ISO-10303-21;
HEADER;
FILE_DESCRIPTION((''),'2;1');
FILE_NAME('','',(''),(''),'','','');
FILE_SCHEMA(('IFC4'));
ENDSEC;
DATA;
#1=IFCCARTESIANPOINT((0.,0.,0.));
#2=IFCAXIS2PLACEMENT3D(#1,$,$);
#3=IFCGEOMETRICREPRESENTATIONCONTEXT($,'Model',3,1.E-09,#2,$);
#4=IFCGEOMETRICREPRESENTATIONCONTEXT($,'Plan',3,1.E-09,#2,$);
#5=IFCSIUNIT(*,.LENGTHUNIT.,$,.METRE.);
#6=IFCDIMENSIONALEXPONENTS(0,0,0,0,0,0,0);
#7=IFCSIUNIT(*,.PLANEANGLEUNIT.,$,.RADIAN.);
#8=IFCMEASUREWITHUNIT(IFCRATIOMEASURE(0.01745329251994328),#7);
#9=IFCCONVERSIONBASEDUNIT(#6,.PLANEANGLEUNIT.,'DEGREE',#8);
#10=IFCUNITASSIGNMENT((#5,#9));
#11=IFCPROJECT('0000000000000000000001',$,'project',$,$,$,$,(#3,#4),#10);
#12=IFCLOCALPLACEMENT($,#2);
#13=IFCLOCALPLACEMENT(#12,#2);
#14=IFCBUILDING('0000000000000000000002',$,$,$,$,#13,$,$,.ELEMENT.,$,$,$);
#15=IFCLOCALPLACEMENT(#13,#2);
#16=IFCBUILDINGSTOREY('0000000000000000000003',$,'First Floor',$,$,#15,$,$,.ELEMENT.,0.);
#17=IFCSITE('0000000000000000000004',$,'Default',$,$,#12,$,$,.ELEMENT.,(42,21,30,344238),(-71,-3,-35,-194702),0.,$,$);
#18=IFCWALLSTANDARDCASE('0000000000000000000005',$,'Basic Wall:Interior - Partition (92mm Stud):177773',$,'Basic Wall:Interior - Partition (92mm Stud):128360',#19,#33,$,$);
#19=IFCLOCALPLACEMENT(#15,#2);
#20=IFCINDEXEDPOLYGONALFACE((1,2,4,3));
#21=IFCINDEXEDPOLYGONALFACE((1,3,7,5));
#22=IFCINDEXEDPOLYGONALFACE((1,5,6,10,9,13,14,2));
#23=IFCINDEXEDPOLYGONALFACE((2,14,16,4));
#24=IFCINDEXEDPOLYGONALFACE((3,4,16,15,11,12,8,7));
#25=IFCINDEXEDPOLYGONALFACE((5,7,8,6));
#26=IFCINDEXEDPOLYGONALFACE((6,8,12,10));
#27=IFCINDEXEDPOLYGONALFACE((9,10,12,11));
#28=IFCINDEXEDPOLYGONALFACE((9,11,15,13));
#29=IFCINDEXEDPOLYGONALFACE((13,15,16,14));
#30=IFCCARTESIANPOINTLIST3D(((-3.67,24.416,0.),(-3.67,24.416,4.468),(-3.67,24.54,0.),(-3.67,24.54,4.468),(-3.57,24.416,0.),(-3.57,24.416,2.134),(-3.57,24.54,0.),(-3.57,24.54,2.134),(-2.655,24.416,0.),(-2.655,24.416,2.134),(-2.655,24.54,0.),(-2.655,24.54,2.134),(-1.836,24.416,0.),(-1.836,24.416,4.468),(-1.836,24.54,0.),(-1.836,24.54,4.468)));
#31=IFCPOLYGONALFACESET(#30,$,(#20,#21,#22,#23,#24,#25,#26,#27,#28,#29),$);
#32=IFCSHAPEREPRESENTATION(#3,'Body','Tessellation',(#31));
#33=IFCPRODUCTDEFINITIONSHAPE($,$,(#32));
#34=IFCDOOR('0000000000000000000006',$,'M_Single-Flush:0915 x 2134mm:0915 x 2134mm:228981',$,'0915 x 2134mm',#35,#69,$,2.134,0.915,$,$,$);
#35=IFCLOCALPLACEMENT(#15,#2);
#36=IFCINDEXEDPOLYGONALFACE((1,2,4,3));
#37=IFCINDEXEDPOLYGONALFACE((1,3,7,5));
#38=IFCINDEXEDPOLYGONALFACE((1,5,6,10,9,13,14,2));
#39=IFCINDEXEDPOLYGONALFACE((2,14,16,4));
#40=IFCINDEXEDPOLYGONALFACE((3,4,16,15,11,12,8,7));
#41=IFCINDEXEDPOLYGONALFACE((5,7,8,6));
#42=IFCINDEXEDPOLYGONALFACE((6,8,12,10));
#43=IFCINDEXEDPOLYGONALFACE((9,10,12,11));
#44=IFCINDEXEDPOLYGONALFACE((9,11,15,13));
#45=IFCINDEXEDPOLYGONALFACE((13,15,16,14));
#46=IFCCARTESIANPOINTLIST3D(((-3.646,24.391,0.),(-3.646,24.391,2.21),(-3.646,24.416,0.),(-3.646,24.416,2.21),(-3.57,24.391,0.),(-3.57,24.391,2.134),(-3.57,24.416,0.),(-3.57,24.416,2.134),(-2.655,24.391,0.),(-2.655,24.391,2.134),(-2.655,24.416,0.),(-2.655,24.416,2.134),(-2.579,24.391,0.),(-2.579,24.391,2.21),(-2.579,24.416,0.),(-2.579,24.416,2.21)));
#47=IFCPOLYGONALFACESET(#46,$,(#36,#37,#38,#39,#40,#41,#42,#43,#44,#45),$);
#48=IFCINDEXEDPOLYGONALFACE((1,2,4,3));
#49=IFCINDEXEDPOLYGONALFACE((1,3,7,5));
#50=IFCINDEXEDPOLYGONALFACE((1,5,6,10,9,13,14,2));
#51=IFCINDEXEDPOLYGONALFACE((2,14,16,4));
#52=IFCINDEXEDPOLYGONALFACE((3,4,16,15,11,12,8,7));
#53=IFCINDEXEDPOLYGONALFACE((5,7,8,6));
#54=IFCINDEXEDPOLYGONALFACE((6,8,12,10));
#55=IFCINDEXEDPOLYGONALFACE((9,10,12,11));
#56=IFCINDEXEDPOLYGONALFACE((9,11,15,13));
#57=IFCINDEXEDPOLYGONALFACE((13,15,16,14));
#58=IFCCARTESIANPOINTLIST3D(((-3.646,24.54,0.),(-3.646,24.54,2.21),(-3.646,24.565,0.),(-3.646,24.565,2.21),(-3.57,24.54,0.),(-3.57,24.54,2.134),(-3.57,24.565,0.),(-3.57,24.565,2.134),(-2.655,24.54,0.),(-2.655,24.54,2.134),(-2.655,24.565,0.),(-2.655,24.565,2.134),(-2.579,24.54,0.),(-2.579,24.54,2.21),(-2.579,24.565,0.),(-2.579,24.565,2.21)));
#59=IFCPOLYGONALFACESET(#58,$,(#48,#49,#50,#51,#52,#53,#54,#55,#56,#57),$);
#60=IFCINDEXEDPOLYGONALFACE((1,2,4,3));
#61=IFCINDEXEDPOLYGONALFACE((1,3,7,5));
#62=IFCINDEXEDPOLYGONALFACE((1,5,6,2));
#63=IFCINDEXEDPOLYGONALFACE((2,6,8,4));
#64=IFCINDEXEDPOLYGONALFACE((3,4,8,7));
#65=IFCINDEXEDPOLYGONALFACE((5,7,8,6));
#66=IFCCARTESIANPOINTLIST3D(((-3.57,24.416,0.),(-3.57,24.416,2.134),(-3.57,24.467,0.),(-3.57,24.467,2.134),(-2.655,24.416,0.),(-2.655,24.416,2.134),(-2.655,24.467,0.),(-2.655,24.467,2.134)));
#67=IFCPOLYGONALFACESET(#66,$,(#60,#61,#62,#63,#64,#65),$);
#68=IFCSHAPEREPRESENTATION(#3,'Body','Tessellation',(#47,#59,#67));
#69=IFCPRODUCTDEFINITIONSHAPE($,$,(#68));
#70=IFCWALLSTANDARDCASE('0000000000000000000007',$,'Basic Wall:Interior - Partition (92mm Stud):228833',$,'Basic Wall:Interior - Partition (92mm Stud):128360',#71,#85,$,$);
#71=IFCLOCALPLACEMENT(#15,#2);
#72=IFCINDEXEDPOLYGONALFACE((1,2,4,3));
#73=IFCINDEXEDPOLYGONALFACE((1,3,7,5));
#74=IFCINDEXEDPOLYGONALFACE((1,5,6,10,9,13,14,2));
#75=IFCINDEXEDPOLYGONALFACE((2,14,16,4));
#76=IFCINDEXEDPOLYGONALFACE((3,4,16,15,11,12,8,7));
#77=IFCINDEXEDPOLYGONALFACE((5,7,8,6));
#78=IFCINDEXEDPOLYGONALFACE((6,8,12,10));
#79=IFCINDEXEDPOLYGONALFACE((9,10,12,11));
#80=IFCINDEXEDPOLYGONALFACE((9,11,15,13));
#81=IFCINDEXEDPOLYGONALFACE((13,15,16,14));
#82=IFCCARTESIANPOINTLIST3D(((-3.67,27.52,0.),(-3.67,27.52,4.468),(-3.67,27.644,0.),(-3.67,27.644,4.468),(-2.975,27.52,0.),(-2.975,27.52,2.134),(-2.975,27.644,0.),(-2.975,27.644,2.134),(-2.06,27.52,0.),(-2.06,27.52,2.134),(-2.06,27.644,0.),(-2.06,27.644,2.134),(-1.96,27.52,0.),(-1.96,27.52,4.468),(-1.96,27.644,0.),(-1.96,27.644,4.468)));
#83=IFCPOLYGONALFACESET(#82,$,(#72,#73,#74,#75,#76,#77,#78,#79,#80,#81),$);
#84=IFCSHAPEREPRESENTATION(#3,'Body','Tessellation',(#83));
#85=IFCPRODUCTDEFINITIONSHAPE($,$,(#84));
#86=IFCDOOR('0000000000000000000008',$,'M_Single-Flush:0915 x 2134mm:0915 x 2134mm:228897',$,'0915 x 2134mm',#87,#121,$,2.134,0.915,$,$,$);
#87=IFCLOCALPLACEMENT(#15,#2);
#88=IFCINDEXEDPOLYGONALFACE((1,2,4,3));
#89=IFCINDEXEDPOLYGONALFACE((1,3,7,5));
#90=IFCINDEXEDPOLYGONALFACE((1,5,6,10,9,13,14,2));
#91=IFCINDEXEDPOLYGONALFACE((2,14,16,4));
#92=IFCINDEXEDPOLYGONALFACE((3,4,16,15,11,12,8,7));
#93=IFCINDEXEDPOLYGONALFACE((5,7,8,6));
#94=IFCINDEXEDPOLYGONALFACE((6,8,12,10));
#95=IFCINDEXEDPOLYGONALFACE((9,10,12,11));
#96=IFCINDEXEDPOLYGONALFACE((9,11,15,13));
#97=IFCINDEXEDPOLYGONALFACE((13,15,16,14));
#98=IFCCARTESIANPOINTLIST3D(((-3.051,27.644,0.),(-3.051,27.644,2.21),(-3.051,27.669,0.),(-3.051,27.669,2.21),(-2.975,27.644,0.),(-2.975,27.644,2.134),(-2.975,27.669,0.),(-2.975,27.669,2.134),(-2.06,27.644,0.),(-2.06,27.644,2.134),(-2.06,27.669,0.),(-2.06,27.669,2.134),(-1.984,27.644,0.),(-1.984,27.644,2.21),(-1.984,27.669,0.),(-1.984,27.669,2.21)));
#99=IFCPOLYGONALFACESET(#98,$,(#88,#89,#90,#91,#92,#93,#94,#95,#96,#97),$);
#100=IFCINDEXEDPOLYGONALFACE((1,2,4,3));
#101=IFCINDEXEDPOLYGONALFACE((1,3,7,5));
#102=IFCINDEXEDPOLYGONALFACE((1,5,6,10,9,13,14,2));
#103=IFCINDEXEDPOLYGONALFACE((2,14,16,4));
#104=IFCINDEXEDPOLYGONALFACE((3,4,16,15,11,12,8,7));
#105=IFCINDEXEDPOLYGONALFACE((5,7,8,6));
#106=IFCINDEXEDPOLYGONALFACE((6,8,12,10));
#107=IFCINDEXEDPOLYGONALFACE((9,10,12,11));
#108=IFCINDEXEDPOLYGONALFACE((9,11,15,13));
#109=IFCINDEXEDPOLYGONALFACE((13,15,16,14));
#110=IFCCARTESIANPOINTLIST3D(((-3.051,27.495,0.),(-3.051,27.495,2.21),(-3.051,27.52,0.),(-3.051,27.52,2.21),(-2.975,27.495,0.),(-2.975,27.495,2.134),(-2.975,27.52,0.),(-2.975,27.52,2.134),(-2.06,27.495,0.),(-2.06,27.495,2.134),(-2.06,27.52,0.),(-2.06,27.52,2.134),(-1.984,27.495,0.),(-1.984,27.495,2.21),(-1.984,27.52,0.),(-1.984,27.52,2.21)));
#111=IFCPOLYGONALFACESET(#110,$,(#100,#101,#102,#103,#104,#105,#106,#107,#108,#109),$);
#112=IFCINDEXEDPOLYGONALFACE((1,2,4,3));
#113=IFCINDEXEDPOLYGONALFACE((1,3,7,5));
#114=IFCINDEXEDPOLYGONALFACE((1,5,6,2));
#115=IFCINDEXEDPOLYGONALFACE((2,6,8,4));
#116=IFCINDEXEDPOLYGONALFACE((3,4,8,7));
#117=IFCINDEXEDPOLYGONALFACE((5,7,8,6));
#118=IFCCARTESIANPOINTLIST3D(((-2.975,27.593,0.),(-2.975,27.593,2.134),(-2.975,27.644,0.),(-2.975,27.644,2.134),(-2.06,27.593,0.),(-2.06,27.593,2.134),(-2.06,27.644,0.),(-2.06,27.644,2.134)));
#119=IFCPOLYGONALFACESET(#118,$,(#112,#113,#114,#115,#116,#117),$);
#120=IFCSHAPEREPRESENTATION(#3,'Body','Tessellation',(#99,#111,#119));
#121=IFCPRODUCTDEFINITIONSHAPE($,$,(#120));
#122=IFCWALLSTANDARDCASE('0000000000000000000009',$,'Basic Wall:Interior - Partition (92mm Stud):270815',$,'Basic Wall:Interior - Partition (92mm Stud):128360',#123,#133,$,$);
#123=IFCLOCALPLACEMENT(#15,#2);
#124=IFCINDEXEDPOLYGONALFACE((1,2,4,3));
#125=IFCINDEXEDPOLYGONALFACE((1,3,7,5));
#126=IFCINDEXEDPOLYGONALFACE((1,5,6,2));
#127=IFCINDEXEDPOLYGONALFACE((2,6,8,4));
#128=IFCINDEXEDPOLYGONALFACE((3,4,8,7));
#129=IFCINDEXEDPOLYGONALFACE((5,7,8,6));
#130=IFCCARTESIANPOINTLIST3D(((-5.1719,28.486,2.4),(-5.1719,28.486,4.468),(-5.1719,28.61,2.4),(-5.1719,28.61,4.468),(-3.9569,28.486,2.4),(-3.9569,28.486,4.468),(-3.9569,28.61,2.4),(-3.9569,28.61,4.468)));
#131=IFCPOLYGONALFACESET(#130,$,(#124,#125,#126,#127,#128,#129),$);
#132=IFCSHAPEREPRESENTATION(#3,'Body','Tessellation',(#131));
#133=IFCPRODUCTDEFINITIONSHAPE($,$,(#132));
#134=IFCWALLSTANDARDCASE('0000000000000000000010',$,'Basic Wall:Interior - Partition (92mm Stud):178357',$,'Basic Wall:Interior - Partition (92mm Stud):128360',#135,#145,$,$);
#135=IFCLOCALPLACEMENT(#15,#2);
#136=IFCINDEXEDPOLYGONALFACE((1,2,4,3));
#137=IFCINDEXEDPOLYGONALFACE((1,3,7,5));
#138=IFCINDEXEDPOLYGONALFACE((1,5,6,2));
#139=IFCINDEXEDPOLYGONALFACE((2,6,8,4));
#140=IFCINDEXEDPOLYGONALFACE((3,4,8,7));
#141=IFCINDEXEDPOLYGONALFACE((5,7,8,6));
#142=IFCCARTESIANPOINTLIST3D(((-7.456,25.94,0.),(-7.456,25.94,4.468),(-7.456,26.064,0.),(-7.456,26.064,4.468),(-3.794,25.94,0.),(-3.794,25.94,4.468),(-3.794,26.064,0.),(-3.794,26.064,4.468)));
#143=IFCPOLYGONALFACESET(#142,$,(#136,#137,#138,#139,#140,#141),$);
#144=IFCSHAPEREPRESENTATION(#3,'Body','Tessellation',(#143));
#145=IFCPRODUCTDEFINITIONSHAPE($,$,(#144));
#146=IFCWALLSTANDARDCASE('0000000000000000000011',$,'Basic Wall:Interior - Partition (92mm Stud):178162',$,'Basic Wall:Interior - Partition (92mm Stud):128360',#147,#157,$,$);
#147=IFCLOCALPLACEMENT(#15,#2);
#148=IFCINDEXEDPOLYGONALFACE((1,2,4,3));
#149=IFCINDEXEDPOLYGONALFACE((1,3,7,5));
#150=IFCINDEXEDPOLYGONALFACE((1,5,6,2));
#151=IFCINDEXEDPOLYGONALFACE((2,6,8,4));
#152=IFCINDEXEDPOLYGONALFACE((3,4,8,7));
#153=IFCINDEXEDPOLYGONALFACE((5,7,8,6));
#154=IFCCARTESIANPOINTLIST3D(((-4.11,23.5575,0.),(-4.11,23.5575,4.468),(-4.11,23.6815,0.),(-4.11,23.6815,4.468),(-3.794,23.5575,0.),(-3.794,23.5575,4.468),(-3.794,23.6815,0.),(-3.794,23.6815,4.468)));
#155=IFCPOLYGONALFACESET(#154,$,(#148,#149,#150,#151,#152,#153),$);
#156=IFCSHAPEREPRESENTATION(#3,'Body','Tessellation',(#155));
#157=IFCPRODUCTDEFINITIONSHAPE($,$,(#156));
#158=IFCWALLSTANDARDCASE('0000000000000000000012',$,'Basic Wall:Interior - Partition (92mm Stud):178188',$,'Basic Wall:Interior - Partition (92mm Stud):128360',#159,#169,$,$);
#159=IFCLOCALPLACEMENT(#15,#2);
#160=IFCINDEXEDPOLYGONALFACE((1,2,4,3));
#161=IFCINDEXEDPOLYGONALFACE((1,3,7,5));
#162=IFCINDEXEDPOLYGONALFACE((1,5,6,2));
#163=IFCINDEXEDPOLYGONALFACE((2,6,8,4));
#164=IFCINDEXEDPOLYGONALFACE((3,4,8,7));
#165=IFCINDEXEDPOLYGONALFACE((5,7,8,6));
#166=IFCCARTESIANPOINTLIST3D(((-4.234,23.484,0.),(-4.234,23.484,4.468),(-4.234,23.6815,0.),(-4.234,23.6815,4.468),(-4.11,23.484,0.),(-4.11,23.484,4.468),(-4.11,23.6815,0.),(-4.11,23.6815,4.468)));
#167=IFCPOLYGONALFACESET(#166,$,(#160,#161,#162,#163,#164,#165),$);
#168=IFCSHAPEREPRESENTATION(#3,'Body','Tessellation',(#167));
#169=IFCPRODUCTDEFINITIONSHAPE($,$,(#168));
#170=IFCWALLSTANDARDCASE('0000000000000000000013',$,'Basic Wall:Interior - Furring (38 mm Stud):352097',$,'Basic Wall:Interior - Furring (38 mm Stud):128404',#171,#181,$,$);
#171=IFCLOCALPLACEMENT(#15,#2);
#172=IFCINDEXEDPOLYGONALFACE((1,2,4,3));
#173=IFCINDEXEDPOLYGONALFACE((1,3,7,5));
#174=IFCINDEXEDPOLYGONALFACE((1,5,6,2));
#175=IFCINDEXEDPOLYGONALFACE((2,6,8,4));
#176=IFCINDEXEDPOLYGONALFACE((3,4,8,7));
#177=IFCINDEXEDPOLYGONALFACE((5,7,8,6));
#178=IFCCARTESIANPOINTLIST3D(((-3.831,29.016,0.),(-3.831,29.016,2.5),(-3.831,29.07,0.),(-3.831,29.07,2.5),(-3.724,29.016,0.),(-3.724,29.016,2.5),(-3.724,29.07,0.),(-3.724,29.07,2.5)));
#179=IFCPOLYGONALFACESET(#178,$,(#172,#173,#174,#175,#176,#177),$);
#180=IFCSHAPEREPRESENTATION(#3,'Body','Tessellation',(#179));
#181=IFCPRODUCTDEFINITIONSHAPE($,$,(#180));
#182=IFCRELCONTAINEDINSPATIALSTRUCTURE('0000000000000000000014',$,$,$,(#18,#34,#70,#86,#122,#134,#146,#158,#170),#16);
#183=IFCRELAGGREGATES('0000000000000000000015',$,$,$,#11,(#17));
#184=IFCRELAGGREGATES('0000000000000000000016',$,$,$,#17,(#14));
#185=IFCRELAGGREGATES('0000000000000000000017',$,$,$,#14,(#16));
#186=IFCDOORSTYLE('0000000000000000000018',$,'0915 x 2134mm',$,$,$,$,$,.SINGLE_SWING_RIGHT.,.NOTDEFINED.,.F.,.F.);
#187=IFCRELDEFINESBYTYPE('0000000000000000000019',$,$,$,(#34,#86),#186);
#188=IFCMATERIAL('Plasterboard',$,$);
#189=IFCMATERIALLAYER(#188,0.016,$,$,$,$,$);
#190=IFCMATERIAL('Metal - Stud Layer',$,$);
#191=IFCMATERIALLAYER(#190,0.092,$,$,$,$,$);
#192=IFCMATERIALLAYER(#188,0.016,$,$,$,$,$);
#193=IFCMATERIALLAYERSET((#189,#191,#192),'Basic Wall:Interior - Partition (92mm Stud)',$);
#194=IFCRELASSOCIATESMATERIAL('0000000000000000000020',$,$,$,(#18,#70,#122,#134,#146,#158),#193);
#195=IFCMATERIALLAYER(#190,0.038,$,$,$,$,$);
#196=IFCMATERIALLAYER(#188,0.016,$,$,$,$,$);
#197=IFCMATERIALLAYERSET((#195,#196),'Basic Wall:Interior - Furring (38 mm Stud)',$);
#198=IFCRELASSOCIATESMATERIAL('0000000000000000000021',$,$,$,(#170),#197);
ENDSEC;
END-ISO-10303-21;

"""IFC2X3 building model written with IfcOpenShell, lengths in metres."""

from ifc_helpers import new_model, entity, si_unit, converted_unit, frame, frame_2d, origin, origin_2d_with_axis, place, context, project, spatial, polyline, rectangle, outline, extrude, source, transform, mapped, material, layer, layer_set, layer_usage, type_object, type_shapes, element, fill, save


model = new_model("IFC2X3")

# Units and contexts
model_context = context("Model", 3, precision=1e-09, world=origin())
plan_context = context("Plan", 3, precision=1e-09, world=origin())
ifc_project = project(units=[si_unit("LENGTHUNIT", "METRE"), converted_unit("PLANEANGLEUNIT", "DEGREE", entity("IfcRatioMeasure", 0.01745329251994328), si_unit("PLANEANGLEUNIT", "RADIAN"), dimensions=[0, 0, 0, 0, 0, 0, 0])], contexts=[model_context, plan_context])

# Site, building, storey
site_placement = place(None, origin())
site = spatial("IfcSite", under=ifc_project, at=site_placement, Name="Default", CompositionType="ELEMENT", RefLatitude=(42, 21, 30, 344238), RefLongitude=(-71, -3, -35, -194702), RefElevation=0.0)
building_placement = place(site_placement, origin())
building = spatial("IfcBuilding", under=site, at=building_placement, CompositionType="ELEMENT")
storey_placement = place(building_placement, origin())
storey = spatial("IfcBuildingStorey", under=building, at=storey_placement, Name="First Floor", CompositionType="ELEMENT", Elevation=0.0)

# Shared definitions
ifc_material_1 = material(Name="Plasterboard")
ifc_layer_1 = layer(ifc_material_1, 0.016)
ifc_material_2 = material(Name="Metal - Stud Layer")
ifc_layer_2 = layer(ifc_material_2, 0.092)
ifc_layer_3 = layer(ifc_material_1, 0.016)
ifc_layer_set_1 = layer_set([ifc_layer_1, ifc_layer_2, ifc_layer_3], Name="Basic Wall:Interior - Partition (92mm Stud)")
ifc_layer_usage_1 = layer_usage(ifc_layer_set_1, "AXIS2", "NEGATIVE", 0.062)
door_style_1 = type_object("IfcDoorStyle", Name="0915 x 2134mm", ConstructionType="NOTDEFINED", OperationType="SINGLE_SWING_RIGHT", ParameterTakesPrecedence=False, Sizeable=False)
shared_shape_1 = source(origin(), model_context, "Body", "SweptSolid", [
    extrude(outline(polyline([(-0.5335, -1.124), (0.5335, -1.124), (0.5335, 1.086), (0.4575, 1.086), (0.4575, -1.048), (-0.4575, -1.048), (-0.4575, 1.086), (-0.5335, 1.086), (-0.5335, -1.124)])), frame((0.4575, 0.124, 1.086), z_axis=(0.0, 1.0, 0.0), x_axis=(1.0, 0.0, 0.0)), (0.0, 0.0, 1.0), 0.025),
    extrude(outline(polyline([(-1.124, -0.5335), (1.086, -0.5335), (1.086, -0.4575), (-1.048, -0.4575), (-1.048, 0.4575), (1.086, 0.4575), (1.086, 0.5335), (-1.124, 0.5335), (-1.124, -0.5335)])), frame((0.4575, -0.025, 1.086), z_axis=(0.0, 1.0, 0.0), x_axis=(0.0, 0.0, -1.0)), (0.0, 0.0, 1.0), 0.025),
    extrude(rectangle(XDim=0.051, YDim=0.915, at=origin_2d_with_axis()), frame((0.4575, 0.0985, 0.0), z_axis=(0.0, 0.0, 1.0), x_axis=(0.0, 1.0, 0.0)), (0.0, 0.0, 1.0), 2.134),
])
type_shapes(door_style_1, [shared_shape_1])

# Shared definitions
ifc_layer_4 = layer(ifc_material_2, 0.038)
ifc_layer_5 = layer(ifc_material_1, 0.016)
ifc_layer_set_2 = layer_set([ifc_layer_4, ifc_layer_5], Name="Basic Wall:Interior - Furring (38 mm Stud)")
ifc_layer_usage_2 = layer_usage(ifc_layer_set_2, "AXIS2", "POSITIVE", -0.027)

# Walls, openings, doors
wall_1_placement = place(storey_placement, frame((-3.67, 24.478, 0.0)))
wall_1 = element("IfcWallStandardCase", 1, at=wall_1_placement, inside=storey, material=ifc_layer_usage_1, Name="Basic Wall:Interior - Partition (92mm Stud):177773", ObjectType="Basic Wall:Interior - Partition (92mm Stud):128360", context=model_context, shape_type="SweptSolid", body=[
    extrude(rectangle(XDim=1.834, YDim=0.124, at=frame_2d((0.917, 0.0), x_axis=(-1.0, 0.0))), origin(), (0.0, 0.0, 1.0), 4.468),
])
opening_1_placement = place(wall_1_placement, frame((1.015, 0.062, 0.0)))
opening_1 = element("IfcOpeningElement", 2, at=opening_1_placement, cuts=wall_1, ObjectType="Opening", context=model_context, shape_type="SweptSolid", body=[
    extrude(rectangle(XDim=0.915, YDim=2.134, at=frame_2d((1.067, 0.4575), x_axis=(0.0, 1.0))), frame((0.0, 0.0, 0.0), z_axis=(0.0, -1.0, 0.0), x_axis=(0.0, 0.0, 1.0)), (0.0, 0.0, 1.0), 0.124),
])
door_1_placement = place(opening_1_placement, frame((0.0, 0.0, 0.0), z_axis=(0.0, 0.0, 1.0), x_axis=(-1.0, 0.0, 0.0)))
door_1 = element("IfcDoor", 3, at=door_1_placement, inside=storey, type_object=door_style_1, Name="M_Single-Flush:0915 x 2134mm:0915 x 2134mm:228981", ObjectType="0915 x 2134mm", OverallHeight=2.134, OverallWidth=0.915, context=model_context, shape_type="MappedRepresentation", body=[
    mapped(shared_shape_1, transform((0.0, 0.0, 0.0), scale=1.0)),
])
fill(opening_1, door_1)
wall_2_placement = place(storey_placement, frame((-1.96, 27.582, 0.0), z_axis=(0.0, 0.0, 1.0), x_axis=(-1.0, 0.0, 0.0)))
wall_2 = element("IfcWallStandardCase", 4, at=wall_2_placement, inside=storey, material=ifc_layer_usage_1, Name="Basic Wall:Interior - Partition (92mm Stud):228833", ObjectType="Basic Wall:Interior - Partition (92mm Stud):128360", context=model_context, shape_type="SweptSolid", body=[
    extrude(rectangle(XDim=1.71, YDim=0.124, at=frame_2d((0.855, 0.0), x_axis=(-1.0, 0.0))), origin(), (0.0, 0.0, 1.0), 4.468),
])
opening_2_placement = place(wall_2_placement, frame((1.015, 0.062, 0.0)))
opening_2 = element("IfcOpeningElement", 5, at=opening_2_placement, cuts=wall_2, ObjectType="Opening", context=model_context, shape_type="SweptSolid", body=[
    extrude(rectangle(XDim=0.915, YDim=2.134, at=frame_2d((1.067, 0.4575), x_axis=(0.0, 1.0))), frame((0.0, 0.0, 0.0), z_axis=(0.0, -1.0, 0.0), x_axis=(0.0, 0.0, 1.0)), (0.0, 0.0, 1.0), 0.124),
])
door_2_placement = place(opening_2_placement, frame((0.0, 0.0, 0.0), z_axis=(0.0, 0.0, 1.0), x_axis=(-1.0, 0.0, 0.0)))
door_2 = element("IfcDoor", 6, at=door_2_placement, inside=storey, type_object=door_style_1, Name="M_Single-Flush:0915 x 2134mm:0915 x 2134mm:228897", ObjectType="0915 x 2134mm", OverallHeight=2.134, OverallWidth=0.915, context=model_context, shape_type="MappedRepresentation", body=[
    mapped(shared_shape_1, transform((0.0, 0.0, 0.0), scale=1.0)),
])
fill(opening_2, door_2)

# Walls
wall_3_placement = place(storey_placement, frame((-3.9569, 28.548, 2.4), z_axis=(0.0, 0.0, 1.0), x_axis=(-1.0, 0.0, 0.0)))
element("IfcWallStandardCase", 7, at=wall_3_placement, inside=storey, material=ifc_layer_usage_1, Name="Basic Wall:Interior - Partition (92mm Stud):270815", ObjectType="Basic Wall:Interior - Partition (92mm Stud):128360", context=model_context, shape_type="SweptSolid", body=[
    extrude(rectangle(XDim=1.215, YDim=0.124, at=frame_2d((0.6075, 0.0), x_axis=(-1.0, 0.0))), origin(), (0.0, 0.0, 1.0), 2.068),
])
wall_4_placement = place(storey_placement, frame((-3.794, 26.002, 0.0), z_axis=(0.0, 0.0, 1.0), x_axis=(-1.0, 0.0, 0.0)))
element("IfcWallStandardCase", 8, at=wall_4_placement, inside=storey, material=ifc_layer_usage_1, Name="Basic Wall:Interior - Partition (92mm Stud):178357", ObjectType="Basic Wall:Interior - Partition (92mm Stud):128360", context=model_context, shape_type="SweptSolid", body=[
    extrude(rectangle(XDim=3.662, YDim=0.124, at=frame_2d((1.831, 0.0), x_axis=(-1.0, 0.0))), origin(), (0.0, 0.0, 1.0), 4.468),
])
wall_5_placement = place(storey_placement, frame((-3.794, 23.6195, 0.0), z_axis=(0.0, 0.0, 1.0), x_axis=(-1.0, 0.0, 0.0)))
element("IfcWallStandardCase", 9, at=wall_5_placement, inside=storey, material=ifc_layer_usage_1, Name="Basic Wall:Interior - Partition (92mm Stud):178162", ObjectType="Basic Wall:Interior - Partition (92mm Stud):128360", context=model_context, shape_type="SweptSolid", body=[
    extrude(rectangle(XDim=0.316, YDim=0.124, at=frame_2d((0.158, 0.0), x_axis=(-1.0, 0.0))), origin(), (0.0, 0.0, 1.0), 4.468),
])
wall_6_placement = place(storey_placement, frame((-4.172, 23.6815, 0.0), z_axis=(0.0, 0.0, 1.0), x_axis=(0.0, -1.0, 0.0)))
element("IfcWallStandardCase", 10, at=wall_6_placement, inside=storey, material=ifc_layer_usage_1, Name="Basic Wall:Interior - Partition (92mm Stud):178188", ObjectType="Basic Wall:Interior - Partition (92mm Stud):128360", context=model_context, shape_type="SweptSolid", body=[
    extrude(rectangle(XDim=0.1975, YDim=0.124, at=frame_2d((0.0988, 0.0), x_axis=(-1.0, 0.0))), origin(), (0.0, 0.0, 1.0), 4.468),
])
wall_7_placement = place(storey_placement, frame((-3.831, 29.043, 0.0)))
element("IfcWallStandardCase", 11, at=wall_7_placement, inside=storey, material=ifc_layer_usage_2, Name="Basic Wall:Interior - Furring (38 mm Stud):352097", ObjectType="Basic Wall:Interior - Furring (38 mm Stud):128404", context=model_context, shape_type="SweptSolid", body=[
    extrude(rectangle(XDim=0.107, YDim=0.054, at=frame_2d((0.0535, 0.0), x_axis=(-1.0, 0.0))), origin(), (0.0, 0.0, 1.0), 2.5),
])

save(model, "model.ifc")
